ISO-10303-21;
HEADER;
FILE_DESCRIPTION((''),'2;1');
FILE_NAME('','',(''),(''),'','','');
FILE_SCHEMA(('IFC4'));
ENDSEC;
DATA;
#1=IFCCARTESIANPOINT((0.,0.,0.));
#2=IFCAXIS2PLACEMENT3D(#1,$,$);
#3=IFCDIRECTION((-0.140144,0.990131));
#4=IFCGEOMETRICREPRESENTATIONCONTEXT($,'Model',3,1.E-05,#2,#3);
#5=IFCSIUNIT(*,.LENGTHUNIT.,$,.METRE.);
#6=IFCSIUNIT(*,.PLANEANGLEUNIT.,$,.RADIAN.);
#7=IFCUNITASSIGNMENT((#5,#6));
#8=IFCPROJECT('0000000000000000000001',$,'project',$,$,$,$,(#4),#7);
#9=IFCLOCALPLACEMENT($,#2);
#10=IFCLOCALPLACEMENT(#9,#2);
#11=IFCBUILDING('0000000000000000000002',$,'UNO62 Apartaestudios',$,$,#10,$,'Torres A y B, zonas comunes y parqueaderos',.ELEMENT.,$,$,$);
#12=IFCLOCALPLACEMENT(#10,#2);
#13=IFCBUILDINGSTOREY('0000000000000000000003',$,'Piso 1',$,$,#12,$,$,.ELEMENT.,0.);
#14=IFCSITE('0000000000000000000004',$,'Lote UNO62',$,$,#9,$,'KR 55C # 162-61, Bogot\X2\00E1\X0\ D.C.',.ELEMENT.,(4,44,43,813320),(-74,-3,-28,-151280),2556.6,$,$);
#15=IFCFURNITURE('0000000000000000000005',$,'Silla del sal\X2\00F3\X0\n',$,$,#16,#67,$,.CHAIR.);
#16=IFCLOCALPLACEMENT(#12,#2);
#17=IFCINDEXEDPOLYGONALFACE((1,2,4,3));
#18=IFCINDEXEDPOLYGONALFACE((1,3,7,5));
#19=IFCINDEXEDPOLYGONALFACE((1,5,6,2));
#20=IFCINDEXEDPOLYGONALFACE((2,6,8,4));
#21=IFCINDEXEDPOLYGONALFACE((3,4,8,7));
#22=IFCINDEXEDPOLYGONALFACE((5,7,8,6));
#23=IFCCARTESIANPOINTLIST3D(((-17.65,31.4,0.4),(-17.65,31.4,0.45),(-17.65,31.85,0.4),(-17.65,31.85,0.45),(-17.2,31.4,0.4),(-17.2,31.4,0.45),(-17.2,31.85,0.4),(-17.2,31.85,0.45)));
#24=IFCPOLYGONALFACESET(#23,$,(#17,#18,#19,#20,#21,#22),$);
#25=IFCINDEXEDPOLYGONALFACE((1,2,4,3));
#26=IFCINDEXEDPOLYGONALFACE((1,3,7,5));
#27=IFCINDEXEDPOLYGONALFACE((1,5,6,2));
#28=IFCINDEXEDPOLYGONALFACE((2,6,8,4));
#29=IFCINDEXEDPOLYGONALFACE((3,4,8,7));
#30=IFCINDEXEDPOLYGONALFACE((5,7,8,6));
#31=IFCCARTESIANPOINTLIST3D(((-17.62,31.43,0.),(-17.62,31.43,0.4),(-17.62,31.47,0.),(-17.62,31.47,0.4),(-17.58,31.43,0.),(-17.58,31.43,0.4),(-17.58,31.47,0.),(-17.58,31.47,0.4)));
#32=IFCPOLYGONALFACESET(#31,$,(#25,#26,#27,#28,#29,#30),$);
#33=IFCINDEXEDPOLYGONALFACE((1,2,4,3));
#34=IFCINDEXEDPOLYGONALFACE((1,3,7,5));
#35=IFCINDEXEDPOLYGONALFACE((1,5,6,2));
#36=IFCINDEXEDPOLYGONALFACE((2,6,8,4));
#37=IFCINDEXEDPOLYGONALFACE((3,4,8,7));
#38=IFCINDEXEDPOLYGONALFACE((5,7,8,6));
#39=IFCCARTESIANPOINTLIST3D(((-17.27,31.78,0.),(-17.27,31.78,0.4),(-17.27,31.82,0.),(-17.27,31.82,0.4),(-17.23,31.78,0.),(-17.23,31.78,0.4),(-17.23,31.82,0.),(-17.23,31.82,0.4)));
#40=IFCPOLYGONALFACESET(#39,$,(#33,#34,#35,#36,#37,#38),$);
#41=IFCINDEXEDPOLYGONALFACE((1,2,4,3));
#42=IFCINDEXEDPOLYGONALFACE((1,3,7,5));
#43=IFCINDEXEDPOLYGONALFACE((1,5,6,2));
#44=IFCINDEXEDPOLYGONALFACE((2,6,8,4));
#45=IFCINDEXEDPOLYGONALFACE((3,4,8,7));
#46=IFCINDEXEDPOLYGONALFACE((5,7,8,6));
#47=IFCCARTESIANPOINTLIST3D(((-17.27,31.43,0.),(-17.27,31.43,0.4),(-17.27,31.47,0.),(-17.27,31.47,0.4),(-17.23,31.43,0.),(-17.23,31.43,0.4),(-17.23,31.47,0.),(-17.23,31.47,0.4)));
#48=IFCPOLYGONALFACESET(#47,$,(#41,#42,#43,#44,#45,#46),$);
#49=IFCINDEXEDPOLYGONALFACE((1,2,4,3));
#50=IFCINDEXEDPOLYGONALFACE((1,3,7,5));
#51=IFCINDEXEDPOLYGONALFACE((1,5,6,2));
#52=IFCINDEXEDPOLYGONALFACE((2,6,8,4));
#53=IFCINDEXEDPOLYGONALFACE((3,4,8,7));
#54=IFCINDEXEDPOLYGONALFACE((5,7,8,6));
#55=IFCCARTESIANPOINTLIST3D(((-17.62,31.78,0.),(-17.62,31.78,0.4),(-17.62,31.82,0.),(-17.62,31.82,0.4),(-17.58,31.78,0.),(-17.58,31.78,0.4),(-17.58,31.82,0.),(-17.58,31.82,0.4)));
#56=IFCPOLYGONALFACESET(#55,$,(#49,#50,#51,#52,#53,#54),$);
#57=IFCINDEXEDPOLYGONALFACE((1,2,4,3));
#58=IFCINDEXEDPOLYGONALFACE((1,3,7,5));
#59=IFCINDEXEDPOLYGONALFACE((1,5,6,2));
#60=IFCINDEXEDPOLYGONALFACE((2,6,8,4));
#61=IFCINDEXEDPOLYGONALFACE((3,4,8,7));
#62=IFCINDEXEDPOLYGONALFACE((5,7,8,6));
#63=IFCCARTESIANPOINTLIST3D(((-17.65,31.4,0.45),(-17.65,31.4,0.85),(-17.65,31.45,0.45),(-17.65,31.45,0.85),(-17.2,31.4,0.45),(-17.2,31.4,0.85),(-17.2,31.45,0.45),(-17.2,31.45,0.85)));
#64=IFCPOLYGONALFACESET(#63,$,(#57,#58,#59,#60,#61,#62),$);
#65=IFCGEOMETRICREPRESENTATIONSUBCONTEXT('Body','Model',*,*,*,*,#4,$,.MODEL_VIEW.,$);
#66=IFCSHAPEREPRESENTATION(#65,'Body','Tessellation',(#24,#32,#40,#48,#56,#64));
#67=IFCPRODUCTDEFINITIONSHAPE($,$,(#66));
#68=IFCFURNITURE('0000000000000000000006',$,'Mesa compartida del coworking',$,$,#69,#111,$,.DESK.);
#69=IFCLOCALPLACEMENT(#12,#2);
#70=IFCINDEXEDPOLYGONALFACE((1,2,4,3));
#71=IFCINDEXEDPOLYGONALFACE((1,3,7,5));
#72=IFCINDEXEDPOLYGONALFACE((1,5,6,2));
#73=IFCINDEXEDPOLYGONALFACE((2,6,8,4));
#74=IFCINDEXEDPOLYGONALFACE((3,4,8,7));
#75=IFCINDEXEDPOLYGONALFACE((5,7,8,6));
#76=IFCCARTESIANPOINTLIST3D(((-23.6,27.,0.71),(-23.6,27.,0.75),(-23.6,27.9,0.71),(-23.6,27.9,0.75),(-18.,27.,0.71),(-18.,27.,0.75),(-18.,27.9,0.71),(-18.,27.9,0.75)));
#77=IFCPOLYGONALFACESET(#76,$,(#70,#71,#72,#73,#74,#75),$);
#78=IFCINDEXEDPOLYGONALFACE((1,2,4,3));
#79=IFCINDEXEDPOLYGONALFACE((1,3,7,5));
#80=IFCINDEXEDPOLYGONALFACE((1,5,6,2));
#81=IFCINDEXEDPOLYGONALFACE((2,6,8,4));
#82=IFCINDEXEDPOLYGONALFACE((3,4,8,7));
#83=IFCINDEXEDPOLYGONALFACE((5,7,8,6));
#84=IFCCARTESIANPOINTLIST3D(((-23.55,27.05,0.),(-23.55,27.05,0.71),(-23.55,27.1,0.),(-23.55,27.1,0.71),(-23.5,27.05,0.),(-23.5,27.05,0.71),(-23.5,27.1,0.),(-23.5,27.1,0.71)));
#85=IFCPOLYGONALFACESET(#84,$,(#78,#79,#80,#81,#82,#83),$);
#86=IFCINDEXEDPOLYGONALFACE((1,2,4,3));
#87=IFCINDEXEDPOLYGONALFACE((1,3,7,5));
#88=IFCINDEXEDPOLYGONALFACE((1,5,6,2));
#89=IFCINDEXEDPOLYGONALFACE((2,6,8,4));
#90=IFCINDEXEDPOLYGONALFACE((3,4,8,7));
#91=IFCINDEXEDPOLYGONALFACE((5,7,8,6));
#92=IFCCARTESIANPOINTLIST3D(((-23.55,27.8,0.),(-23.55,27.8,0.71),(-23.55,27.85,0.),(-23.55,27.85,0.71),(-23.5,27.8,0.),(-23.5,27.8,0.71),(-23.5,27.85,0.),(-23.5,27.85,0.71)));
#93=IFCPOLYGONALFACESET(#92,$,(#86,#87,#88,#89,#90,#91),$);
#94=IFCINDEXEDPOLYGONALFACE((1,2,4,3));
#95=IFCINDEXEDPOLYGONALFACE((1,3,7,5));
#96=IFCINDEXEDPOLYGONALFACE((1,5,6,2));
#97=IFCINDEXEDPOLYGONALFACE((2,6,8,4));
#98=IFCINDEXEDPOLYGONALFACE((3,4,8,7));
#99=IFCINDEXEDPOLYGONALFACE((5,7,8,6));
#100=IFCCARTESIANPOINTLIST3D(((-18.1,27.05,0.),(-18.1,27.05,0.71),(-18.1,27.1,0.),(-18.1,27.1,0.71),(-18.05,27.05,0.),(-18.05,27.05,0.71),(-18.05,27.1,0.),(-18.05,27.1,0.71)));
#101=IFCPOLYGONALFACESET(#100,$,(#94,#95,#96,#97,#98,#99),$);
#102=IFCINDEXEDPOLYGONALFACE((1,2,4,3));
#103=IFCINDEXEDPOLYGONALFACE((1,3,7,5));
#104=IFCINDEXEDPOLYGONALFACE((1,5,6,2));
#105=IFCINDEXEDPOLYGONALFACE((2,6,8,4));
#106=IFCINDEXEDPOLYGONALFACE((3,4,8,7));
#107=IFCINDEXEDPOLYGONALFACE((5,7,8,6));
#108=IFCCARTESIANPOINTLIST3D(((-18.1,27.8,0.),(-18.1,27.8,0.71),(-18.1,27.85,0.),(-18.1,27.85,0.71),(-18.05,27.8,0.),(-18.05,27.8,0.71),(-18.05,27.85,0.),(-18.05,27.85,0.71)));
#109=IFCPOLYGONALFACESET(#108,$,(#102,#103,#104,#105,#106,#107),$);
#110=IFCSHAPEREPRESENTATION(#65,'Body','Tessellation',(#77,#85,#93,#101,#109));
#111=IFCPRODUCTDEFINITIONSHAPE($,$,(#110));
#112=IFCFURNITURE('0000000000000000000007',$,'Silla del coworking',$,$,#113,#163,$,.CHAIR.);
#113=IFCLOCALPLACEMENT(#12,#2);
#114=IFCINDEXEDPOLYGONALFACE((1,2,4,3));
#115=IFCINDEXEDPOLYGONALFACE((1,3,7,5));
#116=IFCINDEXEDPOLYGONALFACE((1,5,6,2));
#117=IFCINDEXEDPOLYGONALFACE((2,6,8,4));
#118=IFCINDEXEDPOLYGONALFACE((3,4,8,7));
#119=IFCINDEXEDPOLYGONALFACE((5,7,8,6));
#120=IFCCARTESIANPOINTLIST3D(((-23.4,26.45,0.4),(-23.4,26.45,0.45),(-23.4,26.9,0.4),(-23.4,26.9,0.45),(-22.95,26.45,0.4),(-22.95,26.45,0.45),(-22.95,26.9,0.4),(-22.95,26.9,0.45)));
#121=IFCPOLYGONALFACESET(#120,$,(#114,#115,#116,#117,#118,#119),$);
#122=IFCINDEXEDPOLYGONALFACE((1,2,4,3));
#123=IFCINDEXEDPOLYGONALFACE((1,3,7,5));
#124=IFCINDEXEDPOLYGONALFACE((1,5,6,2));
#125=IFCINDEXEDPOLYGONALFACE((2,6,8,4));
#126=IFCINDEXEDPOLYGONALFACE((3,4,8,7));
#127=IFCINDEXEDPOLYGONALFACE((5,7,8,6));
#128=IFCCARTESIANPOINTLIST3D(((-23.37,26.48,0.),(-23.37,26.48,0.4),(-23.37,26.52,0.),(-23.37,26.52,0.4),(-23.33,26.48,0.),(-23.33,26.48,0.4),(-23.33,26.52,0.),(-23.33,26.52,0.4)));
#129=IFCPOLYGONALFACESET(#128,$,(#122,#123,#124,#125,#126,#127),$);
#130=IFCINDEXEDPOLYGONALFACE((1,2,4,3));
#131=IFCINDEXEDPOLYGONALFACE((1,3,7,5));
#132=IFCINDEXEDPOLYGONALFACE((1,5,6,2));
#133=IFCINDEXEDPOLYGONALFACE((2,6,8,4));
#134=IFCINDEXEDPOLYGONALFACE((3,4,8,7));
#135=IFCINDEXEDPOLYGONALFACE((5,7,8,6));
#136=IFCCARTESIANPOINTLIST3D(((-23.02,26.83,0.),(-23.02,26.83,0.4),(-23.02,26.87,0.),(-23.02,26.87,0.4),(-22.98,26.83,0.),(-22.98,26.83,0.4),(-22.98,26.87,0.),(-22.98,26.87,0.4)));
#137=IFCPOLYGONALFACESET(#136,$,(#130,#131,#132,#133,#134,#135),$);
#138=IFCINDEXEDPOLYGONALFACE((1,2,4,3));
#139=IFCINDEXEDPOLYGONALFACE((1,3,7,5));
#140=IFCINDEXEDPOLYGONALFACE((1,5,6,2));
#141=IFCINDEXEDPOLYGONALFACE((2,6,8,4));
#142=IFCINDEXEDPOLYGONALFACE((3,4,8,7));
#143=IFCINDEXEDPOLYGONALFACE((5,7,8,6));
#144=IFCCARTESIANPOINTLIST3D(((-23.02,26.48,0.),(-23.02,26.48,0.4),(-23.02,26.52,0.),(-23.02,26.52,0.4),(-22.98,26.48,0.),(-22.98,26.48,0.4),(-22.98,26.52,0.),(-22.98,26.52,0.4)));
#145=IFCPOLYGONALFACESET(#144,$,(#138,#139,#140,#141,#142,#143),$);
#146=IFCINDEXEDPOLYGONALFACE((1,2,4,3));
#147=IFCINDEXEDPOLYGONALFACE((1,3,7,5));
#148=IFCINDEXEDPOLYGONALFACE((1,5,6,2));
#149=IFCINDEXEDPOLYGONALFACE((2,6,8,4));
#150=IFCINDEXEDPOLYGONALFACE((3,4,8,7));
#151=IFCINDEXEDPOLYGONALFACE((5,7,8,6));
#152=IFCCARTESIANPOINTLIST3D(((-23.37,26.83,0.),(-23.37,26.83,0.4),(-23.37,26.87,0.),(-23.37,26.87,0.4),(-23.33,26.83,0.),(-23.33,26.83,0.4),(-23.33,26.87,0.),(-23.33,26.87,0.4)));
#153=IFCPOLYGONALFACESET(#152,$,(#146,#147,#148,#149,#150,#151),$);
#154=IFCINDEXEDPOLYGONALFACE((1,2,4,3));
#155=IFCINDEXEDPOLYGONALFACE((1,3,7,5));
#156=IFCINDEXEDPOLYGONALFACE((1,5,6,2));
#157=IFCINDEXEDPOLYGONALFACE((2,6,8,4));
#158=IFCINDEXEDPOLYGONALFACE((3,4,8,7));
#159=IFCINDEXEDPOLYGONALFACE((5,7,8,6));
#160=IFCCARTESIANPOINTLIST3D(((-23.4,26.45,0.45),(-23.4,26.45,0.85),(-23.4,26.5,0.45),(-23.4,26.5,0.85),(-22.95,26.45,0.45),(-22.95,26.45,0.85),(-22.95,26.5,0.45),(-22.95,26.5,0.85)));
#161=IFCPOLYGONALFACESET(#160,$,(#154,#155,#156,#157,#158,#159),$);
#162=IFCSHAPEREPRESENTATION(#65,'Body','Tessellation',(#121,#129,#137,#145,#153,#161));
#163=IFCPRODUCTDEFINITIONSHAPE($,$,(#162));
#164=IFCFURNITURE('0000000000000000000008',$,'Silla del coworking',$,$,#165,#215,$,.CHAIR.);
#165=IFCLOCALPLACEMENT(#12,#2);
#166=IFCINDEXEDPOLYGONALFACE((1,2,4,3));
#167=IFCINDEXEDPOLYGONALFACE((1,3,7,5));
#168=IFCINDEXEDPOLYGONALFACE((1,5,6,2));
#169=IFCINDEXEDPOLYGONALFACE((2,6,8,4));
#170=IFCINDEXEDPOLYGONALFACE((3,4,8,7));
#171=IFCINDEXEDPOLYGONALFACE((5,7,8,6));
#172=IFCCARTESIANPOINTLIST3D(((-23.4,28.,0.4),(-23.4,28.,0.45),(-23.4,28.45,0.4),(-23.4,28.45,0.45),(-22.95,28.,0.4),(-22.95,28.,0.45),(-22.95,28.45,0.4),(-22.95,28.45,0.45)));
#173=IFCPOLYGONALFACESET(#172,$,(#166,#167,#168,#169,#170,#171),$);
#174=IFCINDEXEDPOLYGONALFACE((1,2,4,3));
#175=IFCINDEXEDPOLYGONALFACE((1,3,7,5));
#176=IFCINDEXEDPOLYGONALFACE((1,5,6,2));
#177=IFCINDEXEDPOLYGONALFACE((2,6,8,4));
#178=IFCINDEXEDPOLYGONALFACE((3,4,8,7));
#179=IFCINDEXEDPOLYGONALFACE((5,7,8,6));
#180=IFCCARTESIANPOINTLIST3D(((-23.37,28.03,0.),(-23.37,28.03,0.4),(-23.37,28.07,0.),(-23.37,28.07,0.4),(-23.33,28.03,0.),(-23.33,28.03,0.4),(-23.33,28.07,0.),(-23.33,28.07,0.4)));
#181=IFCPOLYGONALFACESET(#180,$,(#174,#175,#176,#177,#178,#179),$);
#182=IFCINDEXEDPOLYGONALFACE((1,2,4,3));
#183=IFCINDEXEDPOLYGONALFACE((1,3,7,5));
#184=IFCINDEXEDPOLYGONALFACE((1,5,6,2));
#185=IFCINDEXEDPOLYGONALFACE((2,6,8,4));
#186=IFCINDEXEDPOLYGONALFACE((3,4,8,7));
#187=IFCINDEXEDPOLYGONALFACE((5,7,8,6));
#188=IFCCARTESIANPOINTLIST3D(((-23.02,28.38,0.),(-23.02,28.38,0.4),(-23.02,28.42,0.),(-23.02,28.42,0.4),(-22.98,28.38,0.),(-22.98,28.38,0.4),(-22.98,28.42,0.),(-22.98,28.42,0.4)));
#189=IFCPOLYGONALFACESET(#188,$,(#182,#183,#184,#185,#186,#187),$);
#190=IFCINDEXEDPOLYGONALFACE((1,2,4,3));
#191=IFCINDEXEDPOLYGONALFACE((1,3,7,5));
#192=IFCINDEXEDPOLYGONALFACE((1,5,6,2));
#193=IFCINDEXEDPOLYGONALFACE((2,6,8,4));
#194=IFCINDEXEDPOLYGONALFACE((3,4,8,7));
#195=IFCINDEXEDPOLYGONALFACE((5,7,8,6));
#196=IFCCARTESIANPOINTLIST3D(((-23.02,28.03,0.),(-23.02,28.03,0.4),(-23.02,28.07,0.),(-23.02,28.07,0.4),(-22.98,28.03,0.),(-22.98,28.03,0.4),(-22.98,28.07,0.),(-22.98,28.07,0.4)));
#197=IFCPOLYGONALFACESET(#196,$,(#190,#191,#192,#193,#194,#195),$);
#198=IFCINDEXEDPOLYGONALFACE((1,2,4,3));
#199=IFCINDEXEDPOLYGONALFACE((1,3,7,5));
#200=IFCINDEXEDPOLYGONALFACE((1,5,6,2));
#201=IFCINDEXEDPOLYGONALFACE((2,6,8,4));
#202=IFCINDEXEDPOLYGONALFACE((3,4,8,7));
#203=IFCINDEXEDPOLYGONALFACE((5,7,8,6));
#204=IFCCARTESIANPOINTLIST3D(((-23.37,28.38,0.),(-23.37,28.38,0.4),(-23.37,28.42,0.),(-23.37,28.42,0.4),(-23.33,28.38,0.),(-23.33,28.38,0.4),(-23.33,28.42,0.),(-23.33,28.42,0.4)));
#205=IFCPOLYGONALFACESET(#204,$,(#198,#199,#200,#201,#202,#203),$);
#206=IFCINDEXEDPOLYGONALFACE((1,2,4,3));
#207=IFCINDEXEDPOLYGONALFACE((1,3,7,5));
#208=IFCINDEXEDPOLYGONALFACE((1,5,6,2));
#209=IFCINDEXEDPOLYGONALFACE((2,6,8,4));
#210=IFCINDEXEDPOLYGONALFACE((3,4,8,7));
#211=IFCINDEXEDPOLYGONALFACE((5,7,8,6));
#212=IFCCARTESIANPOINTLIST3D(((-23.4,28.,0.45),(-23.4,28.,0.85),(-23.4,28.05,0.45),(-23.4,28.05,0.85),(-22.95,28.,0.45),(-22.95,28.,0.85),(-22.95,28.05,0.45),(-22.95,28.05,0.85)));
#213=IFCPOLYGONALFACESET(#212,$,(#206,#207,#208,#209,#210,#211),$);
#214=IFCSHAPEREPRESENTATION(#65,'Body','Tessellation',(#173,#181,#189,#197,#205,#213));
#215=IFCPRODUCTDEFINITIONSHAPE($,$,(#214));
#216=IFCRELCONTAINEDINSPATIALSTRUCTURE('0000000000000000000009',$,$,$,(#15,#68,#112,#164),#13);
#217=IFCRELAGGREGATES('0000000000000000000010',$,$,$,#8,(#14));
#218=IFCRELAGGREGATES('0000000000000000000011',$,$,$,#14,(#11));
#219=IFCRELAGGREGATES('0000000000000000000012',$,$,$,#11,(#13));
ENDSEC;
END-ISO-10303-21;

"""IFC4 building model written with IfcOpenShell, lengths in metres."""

from ifc_helpers import new_model, si_unit, direction, frame, frame_2d, origin, place, context, subcontext, project, spatial, rectangle, extrude, element, save


model = new_model("IFC4")

# Units and contexts
model_context = context("Model", 3, precision=1e-05, world=origin(), true_north=direction((-0.140144, 0.990131)))
body_context = subcontext(model_context, "Body", "Model", "MODEL_VIEW")
ifc_project = project(units=[si_unit("LENGTHUNIT", "METRE"), si_unit("PLANEANGLEUNIT", "RADIAN")], contexts=[model_context])

# Site, building, storey
site_placement = place(None, origin())
site = spatial("IfcSite", under=ifc_project, at=site_placement, Name="Lote UNO62", LongName="KR 55C # 162-61, Bogotá D.C.", CompositionType="ELEMENT", RefLatitude=(4, 44, 43, 813320), RefLongitude=(-74, -3, -28, -151280), RefElevation=2556.6)
building_placement = place(site_placement, origin())
building = spatial("IfcBuilding", under=site, at=building_placement, Name="UNO62 Apartaestudios", LongName="Torres A y B, zonas comunes y parqueaderos", CompositionType="ELEMENT")
storey_placement = place(building_placement, origin())
storey = spatial("IfcBuildingStorey", under=building, at=storey_placement, Name="Piso 1", CompositionType="ELEMENT", Elevation=0.0)

# Furniture
furniture_1_placement = place(storey_placement, origin())
element("IfcFurniture", 1, at=furniture_1_placement, inside=storey, Name="Silla del salón", PredefinedType="CHAIR", context=body_context, shape_type="SweptSolid", body=[
    extrude(rectangle(XDim=0.45, YDim=0.45, at=frame_2d((-17.425, 31.625))), frame((0.0, 0.0, 0.4)), (0.0, 0.0, 1.0), 0.05),
    extrude(rectangle(XDim=0.04, YDim=0.04, at=frame_2d((-17.6, 31.45))), origin(), (0.0, 0.0, 1.0), 0.4),
    extrude(rectangle(XDim=0.04, YDim=0.04, at=frame_2d((-17.25, 31.8))), origin(), (0.0, 0.0, 1.0), 0.4),
    extrude(rectangle(XDim=0.04, YDim=0.04, at=frame_2d((-17.25, 31.45))), origin(), (0.0, 0.0, 1.0), 0.4),
    extrude(rectangle(XDim=0.04, YDim=0.04, at=frame_2d((-17.6, 31.8))), origin(), (0.0, 0.0, 1.0), 0.4),
    extrude(rectangle(XDim=0.45, YDim=0.05, at=frame_2d((-17.425, 31.425))), frame((0.0, 0.0, 0.45)), (0.0, 0.0, 1.0), 0.4),
])
furniture_2_placement = place(storey_placement, origin())
element("IfcFurniture", 2, at=furniture_2_placement, inside=storey, Name="Mesa compartida del coworking", PredefinedType="DESK", context=body_context, shape_type="SweptSolid", body=[
    extrude(rectangle(XDim=5.6, YDim=0.9, at=frame_2d((-20.8, 27.45))), frame((0.0, 0.0, 0.71)), (0.0, 0.0, 1.0), 0.04),
    extrude(rectangle(XDim=0.05, YDim=0.05, at=frame_2d((-23.525, 27.075))), origin(), (0.0, 0.0, 1.0), 0.71),
    extrude(rectangle(XDim=0.05, YDim=0.05, at=frame_2d((-23.525, 27.825))), origin(), (0.0, 0.0, 1.0), 0.71),
    extrude(rectangle(XDim=0.05, YDim=0.05, at=frame_2d((-18.075, 27.075))), origin(), (0.0, 0.0, 1.0), 0.71),
    extrude(rectangle(XDim=0.05, YDim=0.05, at=frame_2d((-18.075, 27.825))), origin(), (0.0, 0.0, 1.0), 0.71),
])
furniture_3_placement = place(storey_placement, origin())
element("IfcFurniture", 3, at=furniture_3_placement, inside=storey, Name="Silla del coworking", PredefinedType="CHAIR", context=body_context, shape_type="SweptSolid", body=[
    extrude(rectangle(XDim=0.45, YDim=0.45, at=frame_2d((-23.175, 26.675))), frame((0.0, 0.0, 0.4)), (0.0, 0.0, 1.0), 0.05),
    extrude(rectangle(XDim=0.04, YDim=0.04, at=frame_2d((-23.35, 26.5))), origin(), (0.0, 0.0, 1.0), 0.4),
    extrude(rectangle(XDim=0.04, YDim=0.04, at=frame_2d((-23.0, 26.85))), origin(), (0.0, 0.0, 1.0), 0.4),
    extrude(rectangle(XDim=0.04, YDim=0.04, at=frame_2d((-23.0, 26.5))), origin(), (0.0, 0.0, 1.0), 0.4),
    extrude(rectangle(XDim=0.04, YDim=0.04, at=frame_2d((-23.35, 26.85))), origin(), (0.0, 0.0, 1.0), 0.4),
    extrude(rectangle(XDim=0.45, YDim=0.05, at=frame_2d((-23.175, 26.475))), frame((0.0, 0.0, 0.45)), (0.0, 0.0, 1.0), 0.4),
])
furniture_4_placement = place(storey_placement, origin())
element("IfcFurniture", 4, at=furniture_4_placement, inside=storey, Name="Silla del coworking", PredefinedType="CHAIR", context=body_context, shape_type="SweptSolid", body=[
    extrude(rectangle(XDim=0.45, YDim=0.45, at=frame_2d((-23.175, 28.225))), frame((0.0, 0.0, 0.4)), (0.0, 0.0, 1.0), 0.05),
    extrude(rectangle(XDim=0.04, YDim=0.04, at=frame_2d((-23.35, 28.05))), origin(), (0.0, 0.0, 1.0), 0.4),
    extrude(rectangle(XDim=0.04, YDim=0.04, at=frame_2d((-23.0, 28.4))), origin(), (0.0, 0.0, 1.0), 0.4),
    extrude(rectangle(XDim=0.04, YDim=0.04, at=frame_2d((-23.0, 28.05))), origin(), (0.0, 0.0, 1.0), 0.4),
    extrude(rectangle(XDim=0.04, YDim=0.04, at=frame_2d((-23.35, 28.4))), origin(), (0.0, 0.0, 1.0), 0.4),
    extrude(rectangle(XDim=0.45, YDim=0.05, at=frame_2d((-23.175, 28.025))), frame((0.0, 0.0, 0.45)), (0.0, 0.0, 1.0), 0.4),
])

save(model, "model.ifc")
